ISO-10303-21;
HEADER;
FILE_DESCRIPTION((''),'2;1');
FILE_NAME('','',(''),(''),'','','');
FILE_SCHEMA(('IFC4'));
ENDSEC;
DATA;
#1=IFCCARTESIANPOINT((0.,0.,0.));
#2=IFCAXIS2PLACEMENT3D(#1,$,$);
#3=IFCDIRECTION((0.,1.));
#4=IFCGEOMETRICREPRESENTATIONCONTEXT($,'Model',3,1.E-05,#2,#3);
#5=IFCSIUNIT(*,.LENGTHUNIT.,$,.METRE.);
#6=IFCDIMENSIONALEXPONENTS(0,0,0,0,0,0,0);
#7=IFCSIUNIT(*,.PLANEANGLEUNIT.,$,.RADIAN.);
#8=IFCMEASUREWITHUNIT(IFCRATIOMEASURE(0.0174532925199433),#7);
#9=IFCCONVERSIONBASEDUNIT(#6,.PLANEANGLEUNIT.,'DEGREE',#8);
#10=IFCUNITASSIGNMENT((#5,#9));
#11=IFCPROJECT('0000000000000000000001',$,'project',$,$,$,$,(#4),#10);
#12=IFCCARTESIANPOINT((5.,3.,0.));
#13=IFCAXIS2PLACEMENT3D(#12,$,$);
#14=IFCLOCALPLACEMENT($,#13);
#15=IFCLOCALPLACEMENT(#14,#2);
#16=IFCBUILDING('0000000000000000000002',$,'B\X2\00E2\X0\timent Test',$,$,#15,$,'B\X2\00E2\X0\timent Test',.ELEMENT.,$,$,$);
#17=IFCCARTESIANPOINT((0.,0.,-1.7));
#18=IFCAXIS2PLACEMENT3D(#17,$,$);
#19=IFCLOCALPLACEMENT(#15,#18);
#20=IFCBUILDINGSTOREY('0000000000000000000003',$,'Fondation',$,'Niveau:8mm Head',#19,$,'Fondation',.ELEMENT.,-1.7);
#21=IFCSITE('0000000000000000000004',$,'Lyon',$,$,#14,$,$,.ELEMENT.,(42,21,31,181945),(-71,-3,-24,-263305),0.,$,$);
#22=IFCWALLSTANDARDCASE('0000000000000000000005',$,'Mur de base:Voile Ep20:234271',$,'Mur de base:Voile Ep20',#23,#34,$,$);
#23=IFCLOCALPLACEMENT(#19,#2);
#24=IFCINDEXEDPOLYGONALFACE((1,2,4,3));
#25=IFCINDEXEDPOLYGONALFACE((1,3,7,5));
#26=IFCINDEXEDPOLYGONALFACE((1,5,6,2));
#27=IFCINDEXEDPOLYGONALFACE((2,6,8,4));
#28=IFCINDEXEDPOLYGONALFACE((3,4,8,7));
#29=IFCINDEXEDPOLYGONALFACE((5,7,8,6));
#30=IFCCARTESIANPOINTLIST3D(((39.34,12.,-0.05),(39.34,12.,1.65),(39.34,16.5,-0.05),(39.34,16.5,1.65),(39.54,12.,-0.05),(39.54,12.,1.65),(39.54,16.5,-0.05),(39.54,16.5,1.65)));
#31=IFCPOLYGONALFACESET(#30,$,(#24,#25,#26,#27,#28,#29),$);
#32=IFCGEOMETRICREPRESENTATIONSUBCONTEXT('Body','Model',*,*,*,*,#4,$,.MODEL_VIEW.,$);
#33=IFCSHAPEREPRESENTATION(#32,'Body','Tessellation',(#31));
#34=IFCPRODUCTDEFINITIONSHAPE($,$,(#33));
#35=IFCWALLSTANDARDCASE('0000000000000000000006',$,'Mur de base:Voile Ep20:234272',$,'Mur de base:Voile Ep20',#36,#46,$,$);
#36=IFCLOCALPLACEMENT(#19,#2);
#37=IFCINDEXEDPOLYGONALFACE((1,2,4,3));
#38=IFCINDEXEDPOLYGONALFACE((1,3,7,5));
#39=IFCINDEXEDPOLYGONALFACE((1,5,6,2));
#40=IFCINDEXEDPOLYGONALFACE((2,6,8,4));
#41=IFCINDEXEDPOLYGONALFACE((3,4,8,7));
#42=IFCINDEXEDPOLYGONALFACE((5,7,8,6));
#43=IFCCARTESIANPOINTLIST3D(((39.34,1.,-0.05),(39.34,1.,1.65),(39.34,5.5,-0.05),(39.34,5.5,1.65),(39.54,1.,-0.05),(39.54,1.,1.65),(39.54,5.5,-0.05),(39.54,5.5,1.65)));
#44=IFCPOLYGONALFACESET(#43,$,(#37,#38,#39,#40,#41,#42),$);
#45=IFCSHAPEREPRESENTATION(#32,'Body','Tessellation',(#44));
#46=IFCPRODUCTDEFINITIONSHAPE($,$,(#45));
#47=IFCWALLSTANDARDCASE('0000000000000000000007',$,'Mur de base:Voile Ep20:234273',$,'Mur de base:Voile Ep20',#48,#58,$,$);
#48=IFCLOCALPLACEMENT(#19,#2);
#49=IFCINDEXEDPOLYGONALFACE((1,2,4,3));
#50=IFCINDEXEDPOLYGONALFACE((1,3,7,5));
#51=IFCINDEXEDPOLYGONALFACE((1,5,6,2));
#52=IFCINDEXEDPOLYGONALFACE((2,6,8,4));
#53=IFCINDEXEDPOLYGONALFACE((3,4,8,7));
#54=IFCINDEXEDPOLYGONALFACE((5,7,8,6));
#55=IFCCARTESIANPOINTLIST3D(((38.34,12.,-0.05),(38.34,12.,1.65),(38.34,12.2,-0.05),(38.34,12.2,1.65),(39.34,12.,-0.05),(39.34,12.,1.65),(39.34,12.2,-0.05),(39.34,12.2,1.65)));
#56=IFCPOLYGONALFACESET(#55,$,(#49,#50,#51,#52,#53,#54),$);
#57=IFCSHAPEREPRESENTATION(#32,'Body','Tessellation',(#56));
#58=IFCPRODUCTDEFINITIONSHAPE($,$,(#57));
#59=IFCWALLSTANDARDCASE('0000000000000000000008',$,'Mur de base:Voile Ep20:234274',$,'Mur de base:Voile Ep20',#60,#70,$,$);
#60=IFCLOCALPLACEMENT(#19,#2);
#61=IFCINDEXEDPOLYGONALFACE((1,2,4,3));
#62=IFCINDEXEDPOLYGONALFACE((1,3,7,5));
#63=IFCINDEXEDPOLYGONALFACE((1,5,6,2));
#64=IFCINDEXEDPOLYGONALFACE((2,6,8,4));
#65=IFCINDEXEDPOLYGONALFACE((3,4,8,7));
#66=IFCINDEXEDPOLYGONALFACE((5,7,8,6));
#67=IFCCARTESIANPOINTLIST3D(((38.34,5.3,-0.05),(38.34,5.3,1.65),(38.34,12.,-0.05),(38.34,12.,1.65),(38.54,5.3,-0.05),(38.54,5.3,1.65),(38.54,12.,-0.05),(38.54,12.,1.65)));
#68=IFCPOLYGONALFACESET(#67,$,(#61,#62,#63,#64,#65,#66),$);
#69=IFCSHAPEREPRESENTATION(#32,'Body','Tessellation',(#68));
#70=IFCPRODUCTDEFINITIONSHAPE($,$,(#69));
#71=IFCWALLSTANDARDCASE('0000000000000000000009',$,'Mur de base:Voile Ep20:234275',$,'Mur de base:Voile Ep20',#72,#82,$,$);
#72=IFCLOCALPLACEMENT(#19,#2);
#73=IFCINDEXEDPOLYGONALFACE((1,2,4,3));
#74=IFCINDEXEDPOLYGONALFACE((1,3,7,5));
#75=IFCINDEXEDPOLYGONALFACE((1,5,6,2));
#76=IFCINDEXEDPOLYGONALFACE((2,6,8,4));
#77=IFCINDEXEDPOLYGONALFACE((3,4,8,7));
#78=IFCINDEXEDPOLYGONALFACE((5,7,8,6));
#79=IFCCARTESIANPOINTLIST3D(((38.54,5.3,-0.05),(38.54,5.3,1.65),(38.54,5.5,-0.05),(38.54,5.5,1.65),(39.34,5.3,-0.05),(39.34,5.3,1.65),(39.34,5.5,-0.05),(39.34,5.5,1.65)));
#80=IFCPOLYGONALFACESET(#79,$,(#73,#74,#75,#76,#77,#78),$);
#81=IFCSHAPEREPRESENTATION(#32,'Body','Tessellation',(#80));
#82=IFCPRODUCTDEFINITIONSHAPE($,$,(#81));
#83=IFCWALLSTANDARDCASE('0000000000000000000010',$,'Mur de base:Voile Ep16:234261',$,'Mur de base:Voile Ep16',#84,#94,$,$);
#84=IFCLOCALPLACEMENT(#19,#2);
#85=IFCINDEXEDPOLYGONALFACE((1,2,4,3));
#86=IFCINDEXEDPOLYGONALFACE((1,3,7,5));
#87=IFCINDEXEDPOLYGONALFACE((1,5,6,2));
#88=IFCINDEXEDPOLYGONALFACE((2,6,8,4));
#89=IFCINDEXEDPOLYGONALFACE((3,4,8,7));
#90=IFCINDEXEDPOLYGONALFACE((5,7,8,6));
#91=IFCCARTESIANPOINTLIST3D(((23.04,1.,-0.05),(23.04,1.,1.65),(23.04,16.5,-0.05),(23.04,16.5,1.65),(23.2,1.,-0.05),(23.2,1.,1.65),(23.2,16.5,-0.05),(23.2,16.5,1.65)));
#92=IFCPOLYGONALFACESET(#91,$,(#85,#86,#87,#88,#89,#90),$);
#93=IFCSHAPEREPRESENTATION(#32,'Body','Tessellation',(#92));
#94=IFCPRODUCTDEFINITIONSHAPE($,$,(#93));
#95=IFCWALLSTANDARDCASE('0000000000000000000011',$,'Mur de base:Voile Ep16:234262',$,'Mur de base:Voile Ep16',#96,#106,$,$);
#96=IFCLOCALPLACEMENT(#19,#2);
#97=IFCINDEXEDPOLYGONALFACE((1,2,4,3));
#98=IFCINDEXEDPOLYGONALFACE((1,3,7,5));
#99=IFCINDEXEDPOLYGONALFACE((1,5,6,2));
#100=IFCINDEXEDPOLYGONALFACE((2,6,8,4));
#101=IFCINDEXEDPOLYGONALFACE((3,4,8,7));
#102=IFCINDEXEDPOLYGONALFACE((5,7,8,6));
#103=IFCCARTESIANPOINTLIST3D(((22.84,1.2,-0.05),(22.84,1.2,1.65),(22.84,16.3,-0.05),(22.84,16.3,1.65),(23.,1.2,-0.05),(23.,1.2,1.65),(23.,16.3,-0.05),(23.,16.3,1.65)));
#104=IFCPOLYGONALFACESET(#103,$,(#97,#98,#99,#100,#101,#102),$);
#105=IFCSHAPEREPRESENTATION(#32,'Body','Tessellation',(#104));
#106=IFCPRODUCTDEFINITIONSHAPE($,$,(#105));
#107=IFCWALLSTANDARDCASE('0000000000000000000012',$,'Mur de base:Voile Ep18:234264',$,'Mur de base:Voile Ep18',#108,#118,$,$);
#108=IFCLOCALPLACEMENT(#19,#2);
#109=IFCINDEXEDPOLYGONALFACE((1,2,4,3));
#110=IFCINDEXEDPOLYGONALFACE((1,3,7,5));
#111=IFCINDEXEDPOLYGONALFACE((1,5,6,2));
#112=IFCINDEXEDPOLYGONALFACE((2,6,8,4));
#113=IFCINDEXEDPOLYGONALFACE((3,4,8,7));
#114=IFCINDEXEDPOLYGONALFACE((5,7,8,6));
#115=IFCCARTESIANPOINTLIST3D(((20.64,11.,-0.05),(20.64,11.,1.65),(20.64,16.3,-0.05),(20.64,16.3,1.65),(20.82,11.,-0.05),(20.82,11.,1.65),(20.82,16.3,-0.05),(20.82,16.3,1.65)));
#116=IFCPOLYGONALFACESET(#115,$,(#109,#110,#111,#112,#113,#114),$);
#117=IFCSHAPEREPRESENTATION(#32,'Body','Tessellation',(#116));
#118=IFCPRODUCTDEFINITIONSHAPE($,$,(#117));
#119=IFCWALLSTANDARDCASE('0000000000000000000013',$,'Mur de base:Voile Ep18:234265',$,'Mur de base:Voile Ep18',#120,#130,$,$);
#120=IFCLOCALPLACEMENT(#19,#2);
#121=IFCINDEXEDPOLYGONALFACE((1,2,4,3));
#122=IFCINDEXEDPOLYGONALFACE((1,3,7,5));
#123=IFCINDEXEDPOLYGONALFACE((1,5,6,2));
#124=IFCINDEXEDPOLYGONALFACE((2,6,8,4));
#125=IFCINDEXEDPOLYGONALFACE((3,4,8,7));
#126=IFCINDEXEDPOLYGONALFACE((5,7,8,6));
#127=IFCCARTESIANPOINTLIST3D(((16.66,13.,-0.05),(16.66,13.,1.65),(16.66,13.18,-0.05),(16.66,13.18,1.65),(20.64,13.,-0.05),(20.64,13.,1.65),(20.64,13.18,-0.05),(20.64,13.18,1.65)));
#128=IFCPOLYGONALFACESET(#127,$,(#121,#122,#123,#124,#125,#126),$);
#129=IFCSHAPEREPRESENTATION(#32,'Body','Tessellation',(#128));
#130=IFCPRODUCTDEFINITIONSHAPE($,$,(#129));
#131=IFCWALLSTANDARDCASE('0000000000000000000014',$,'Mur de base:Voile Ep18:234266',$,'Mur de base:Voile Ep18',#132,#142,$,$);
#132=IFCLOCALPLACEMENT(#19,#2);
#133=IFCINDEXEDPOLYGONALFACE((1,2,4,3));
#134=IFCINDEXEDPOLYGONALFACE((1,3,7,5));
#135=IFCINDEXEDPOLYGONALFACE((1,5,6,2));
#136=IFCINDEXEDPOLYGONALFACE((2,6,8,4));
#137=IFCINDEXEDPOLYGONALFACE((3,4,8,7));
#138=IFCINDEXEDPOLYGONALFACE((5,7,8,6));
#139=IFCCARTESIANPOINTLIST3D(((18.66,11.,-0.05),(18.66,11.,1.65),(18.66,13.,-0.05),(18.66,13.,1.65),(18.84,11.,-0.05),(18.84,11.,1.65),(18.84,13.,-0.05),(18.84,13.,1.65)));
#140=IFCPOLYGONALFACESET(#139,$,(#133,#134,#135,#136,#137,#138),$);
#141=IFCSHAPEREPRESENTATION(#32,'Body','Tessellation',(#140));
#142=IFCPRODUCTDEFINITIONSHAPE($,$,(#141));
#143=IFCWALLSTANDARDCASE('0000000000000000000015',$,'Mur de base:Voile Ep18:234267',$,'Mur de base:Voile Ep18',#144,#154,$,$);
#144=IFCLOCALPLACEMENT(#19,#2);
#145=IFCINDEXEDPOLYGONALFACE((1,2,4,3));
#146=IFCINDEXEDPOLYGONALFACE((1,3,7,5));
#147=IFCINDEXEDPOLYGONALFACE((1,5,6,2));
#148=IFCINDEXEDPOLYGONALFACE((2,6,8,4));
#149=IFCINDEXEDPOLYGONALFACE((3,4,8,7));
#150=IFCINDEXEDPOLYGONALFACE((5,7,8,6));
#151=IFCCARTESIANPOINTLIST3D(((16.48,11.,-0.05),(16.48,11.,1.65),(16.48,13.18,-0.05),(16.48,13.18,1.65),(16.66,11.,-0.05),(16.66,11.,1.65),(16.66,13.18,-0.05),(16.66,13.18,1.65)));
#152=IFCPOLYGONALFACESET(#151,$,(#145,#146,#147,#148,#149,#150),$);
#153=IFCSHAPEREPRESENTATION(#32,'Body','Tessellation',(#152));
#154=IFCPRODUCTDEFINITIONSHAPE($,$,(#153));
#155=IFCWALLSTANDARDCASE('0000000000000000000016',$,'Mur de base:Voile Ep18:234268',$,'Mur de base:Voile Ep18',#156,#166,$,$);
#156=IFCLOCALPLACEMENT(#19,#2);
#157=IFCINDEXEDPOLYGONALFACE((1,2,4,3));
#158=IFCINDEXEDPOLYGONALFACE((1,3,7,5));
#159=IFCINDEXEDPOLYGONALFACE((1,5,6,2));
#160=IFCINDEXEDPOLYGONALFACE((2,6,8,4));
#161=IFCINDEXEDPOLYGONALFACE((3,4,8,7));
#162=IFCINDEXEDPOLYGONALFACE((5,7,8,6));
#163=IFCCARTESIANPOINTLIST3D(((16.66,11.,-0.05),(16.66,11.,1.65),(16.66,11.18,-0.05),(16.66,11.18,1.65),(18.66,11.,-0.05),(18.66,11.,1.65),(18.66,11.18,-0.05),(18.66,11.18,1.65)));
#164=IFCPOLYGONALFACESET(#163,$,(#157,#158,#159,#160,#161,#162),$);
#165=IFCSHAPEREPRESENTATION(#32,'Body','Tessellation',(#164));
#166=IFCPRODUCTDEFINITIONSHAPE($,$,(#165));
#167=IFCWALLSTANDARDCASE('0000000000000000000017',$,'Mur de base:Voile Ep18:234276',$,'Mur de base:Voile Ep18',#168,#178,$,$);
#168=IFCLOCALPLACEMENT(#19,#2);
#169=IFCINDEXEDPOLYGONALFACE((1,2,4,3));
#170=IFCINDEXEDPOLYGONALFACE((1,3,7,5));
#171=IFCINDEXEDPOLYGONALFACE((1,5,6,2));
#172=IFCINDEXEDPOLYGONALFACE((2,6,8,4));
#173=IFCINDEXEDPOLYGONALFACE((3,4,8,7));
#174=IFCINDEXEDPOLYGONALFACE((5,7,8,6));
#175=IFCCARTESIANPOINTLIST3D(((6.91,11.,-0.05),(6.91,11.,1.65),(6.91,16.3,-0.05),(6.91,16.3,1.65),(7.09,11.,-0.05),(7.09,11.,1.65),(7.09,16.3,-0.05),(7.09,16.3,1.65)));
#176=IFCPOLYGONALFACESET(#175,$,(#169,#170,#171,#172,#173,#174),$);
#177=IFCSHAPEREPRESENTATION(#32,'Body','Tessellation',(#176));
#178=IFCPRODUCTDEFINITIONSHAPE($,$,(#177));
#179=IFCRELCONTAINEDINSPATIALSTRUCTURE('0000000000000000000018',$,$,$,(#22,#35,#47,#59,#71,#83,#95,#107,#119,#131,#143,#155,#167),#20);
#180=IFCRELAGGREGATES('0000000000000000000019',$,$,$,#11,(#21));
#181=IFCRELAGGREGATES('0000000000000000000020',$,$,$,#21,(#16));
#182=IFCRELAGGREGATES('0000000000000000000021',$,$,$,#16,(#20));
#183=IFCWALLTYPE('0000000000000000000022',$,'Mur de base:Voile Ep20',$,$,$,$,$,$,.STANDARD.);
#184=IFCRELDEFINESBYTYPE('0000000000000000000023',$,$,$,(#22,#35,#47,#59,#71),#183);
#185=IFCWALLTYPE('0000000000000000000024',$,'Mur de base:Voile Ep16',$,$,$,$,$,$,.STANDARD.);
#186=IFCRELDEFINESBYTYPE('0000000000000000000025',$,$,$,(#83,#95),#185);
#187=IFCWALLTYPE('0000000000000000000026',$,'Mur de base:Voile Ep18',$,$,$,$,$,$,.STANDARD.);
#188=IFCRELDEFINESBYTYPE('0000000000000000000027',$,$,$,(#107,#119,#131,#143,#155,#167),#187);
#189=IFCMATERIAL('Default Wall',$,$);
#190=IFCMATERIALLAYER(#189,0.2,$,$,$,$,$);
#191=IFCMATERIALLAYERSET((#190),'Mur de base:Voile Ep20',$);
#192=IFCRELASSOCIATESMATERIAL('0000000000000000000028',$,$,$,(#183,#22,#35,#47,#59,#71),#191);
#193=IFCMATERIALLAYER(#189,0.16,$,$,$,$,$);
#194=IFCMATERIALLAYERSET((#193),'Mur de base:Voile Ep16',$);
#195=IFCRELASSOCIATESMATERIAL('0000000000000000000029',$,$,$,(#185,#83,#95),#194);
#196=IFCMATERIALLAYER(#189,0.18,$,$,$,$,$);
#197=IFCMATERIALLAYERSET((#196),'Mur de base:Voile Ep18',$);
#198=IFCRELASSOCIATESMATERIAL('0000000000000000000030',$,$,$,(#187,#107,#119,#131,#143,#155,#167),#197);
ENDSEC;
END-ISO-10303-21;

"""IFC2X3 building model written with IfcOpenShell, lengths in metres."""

from ifc_helpers import new_model, entity, si_unit, converted_unit, direction, frame, frame_2d, origin, place, context, subcontext, project, spatial, rectangle, extrude, material, layer, layer_set, layer_usage, type_object, element, save


model = new_model("IFC2X3")

# Units and contexts
model_context = context("Model", 3, precision=1e-05, world=origin(), true_north=direction((0.0, 1.0)))
body_context = subcontext(model_context, "Body", "Model", "MODEL_VIEW")
ifc_project = project(units=[si_unit("LENGTHUNIT", "METRE"), converted_unit("PLANEANGLEUNIT", "DEGREE", entity("IfcRatioMeasure", 0.0174532925199433), si_unit("PLANEANGLEUNIT", "RADIAN"), dimensions=[0, 0, 0, 0, 0, 0, 0])], contexts=[model_context])

# Site, building, storey
site_placement = place(None, frame((5.0, 3.0, 0.0)))
site = spatial("IfcSite", under=ifc_project, at=site_placement, Name="Lyon", CompositionType="ELEMENT", RefLatitude=(42, 21, 31, 181945), RefLongitude=(-71, -3, -24, -263305), RefElevation=0.0)
building_placement = place(site_placement, origin())
building = spatial("IfcBuilding", under=site, at=building_placement, Name="Bâtiment Test", LongName="Bâtiment Test", CompositionType="ELEMENT")
storey_placement = place(building_placement, frame((0.0, 0.0, -1.7)))
storey = spatial("IfcBuildingStorey", under=building, at=storey_placement, Name="Fondation", ObjectType="Niveau:8mm Head", LongName="Fondation", CompositionType="ELEMENT", Elevation=-1.7)

# Walls
ifc_material_1 = material(Name="Default Wall")
ifc_layer_1 = layer(ifc_material_1, 0.2)
ifc_layer_set_1 = layer_set([ifc_layer_1], Name="Mur de base:Voile Ep20")
wall_type_1 = type_object("IfcWallType", Name="Mur de base:Voile Ep20", PredefinedType="STANDARD", material=ifc_layer_set_1)
ifc_layer_usage_1 = layer_usage(ifc_layer_set_1, "AXIS2", "NEGATIVE", 0.1)
wall_1_placement = place(storey_placement, frame((39.44, 16.5, -0.05), z_axis=(0.0, 0.0, 1.0), x_axis=(0.0, -1.0, 0.0)))
element("IfcWallStandardCase", 1, at=wall_1_placement, inside=storey, type_object=wall_type_1, material=ifc_layer_usage_1, Name="Mur de base:Voile Ep20:234271", ObjectType="Mur de base:Voile Ep20", context=body_context, shape_type="SweptSolid", body=[
    extrude(rectangle(XDim=4.5, YDim=0.2, at=frame_2d((2.25, 0.0), x_axis=(-1.0, 0.0))), origin(), (0.0, 0.0, 1.0), 1.7),
])
ifc_layer_usage_2 = layer_usage(ifc_layer_set_1, "AXIS2", "NEGATIVE", 0.1)
wall_2_placement = place(storey_placement, frame((39.44, 5.5, -0.05), z_axis=(0.0, 0.0, 1.0), x_axis=(0.0, -1.0, 0.0)))
element("IfcWallStandardCase", 2, at=wall_2_placement, inside=storey, type_object=wall_type_1, material=ifc_layer_usage_2, Name="Mur de base:Voile Ep20:234272", ObjectType="Mur de base:Voile Ep20", context=body_context, shape_type="SweptSolid", body=[
    extrude(rectangle(XDim=4.5, YDim=0.2, at=frame_2d((2.25, 0.0), x_axis=(-1.0, 0.0))), origin(), (0.0, 0.0, 1.0), 1.7),
])
ifc_layer_usage_3 = layer_usage(ifc_layer_set_1, "AXIS2", "NEGATIVE", 0.1)
wall_3_placement = place(storey_placement, frame((39.34, 12.1, -0.05), z_axis=(0.0, 0.0, 1.0), x_axis=(-1.0, 0.0, 0.0)))
element("IfcWallStandardCase", 3, at=wall_3_placement, inside=storey, type_object=wall_type_1, material=ifc_layer_usage_3, Name="Mur de base:Voile Ep20:234273", ObjectType="Mur de base:Voile Ep20", context=body_context, shape_type="SweptSolid", body=[
    extrude(rectangle(XDim=1.0, YDim=0.2, at=frame_2d((0.5, 0.0), x_axis=(-1.0, 0.0))), origin(), (0.0, 0.0, 1.0), 1.7),
])
ifc_layer_usage_4 = layer_usage(ifc_layer_set_1, "AXIS2", "NEGATIVE", 0.1)
wall_4_placement = place(storey_placement, frame((38.44, 12.0, -0.05), z_axis=(0.0, 0.0, 1.0), x_axis=(0.0, -1.0, 0.0)))
element("IfcWallStandardCase", 4, at=wall_4_placement, inside=storey, type_object=wall_type_1, material=ifc_layer_usage_4, Name="Mur de base:Voile Ep20:234274", ObjectType="Mur de base:Voile Ep20", context=body_context, shape_type="SweptSolid", body=[
    extrude(rectangle(XDim=6.7, YDim=0.2, at=frame_2d((3.35, 0.0), x_axis=(-1.0, 0.0))), origin(), (0.0, 0.0, 1.0), 1.7),
])
ifc_layer_usage_5 = layer_usage(ifc_layer_set_1, "AXIS2", "NEGATIVE", 0.1)
wall_5_placement = place(storey_placement, frame((38.54, 5.4, -0.05)))
element("IfcWallStandardCase", 5, at=wall_5_placement, inside=storey, type_object=wall_type_1, material=ifc_layer_usage_5, Name="Mur de base:Voile Ep20:234275", ObjectType="Mur de base:Voile Ep20", context=body_context, shape_type="SweptSolid", body=[
    extrude(rectangle(XDim=0.8, YDim=0.2, at=frame_2d((0.4, 0.0), x_axis=(-1.0, 0.0))), origin(), (0.0, 0.0, 1.0), 1.7),
])
ifc_layer_2 = layer(ifc_material_1, 0.16)
ifc_layer_set_2 = layer_set([ifc_layer_2], Name="Mur de base:Voile Ep16")
ifc_layer_usage_6 = layer_usage(ifc_layer_set_2, "AXIS2", "NEGATIVE", 0.08)
wall_type_2 = type_object("IfcWallType", Name="Mur de base:Voile Ep16", PredefinedType="STANDARD", material=ifc_layer_set_2)
wall_6_placement = place(storey_placement, frame((23.12, 1.0, -0.05), z_axis=(0.0, 0.0, 1.0), x_axis=(0.0, 1.0, 0.0)))
element("IfcWallStandardCase", 6, at=wall_6_placement, inside=storey, type_object=wall_type_2, material=ifc_layer_usage_6, Name="Mur de base:Voile Ep16:234261", ObjectType="Mur de base:Voile Ep16", context=body_context, shape_type="SweptSolid", body=[
    extrude(rectangle(XDim=15.5, YDim=0.16, at=frame_2d((7.75, 0.0), x_axis=(-1.0, 0.0))), origin(), (0.0, 0.0, 1.0), 1.7),
])
ifc_layer_usage_7 = layer_usage(ifc_layer_set_2, "AXIS2", "NEGATIVE", 0.08)
wall_7_placement = place(storey_placement, frame((22.92, 16.3, -0.05), z_axis=(0.0, 0.0, 1.0), x_axis=(0.0, -1.0, 0.0)))
element("IfcWallStandardCase", 7, at=wall_7_placement, inside=storey, type_object=wall_type_2, material=ifc_layer_usage_7, Name="Mur de base:Voile Ep16:234262", ObjectType="Mur de base:Voile Ep16", context=body_context, shape_type="SweptSolid", body=[
    extrude(rectangle(XDim=15.1, YDim=0.16, at=frame_2d((7.55, 0.0), x_axis=(-1.0, 0.0))), origin(), (0.0, 0.0, 1.0), 1.7),
])
ifc_layer_3 = layer(ifc_material_1, 0.18)
ifc_layer_set_3 = layer_set([ifc_layer_3], Name="Mur de base:Voile Ep18")
ifc_layer_usage_8 = layer_usage(ifc_layer_set_3, "AXIS2", "NEGATIVE", 0.09)
wall_type_3 = type_object("IfcWallType", Name="Mur de base:Voile Ep18", PredefinedType="STANDARD", material=ifc_layer_set_3)
wall_8_placement = place(storey_placement, frame((20.73, 16.3, -0.05), z_axis=(0.0, 0.0, 1.0), x_axis=(0.0, -1.0, 0.0)))
element("IfcWallStandardCase", 8, at=wall_8_placement, inside=storey, type_object=wall_type_3, material=ifc_layer_usage_8, Name="Mur de base:Voile Ep18:234264", ObjectType="Mur de base:Voile Ep18", context=body_context, shape_type="SweptSolid", body=[
    extrude(rectangle(XDim=5.3, YDim=0.18, at=frame_2d((2.65, 0.0), x_axis=(-1.0, 0.0))), origin(), (0.0, 0.0, 1.0), 1.7),
])
ifc_layer_usage_9 = layer_usage(ifc_layer_set_3, "AXIS2", "NEGATIVE", 0.09)
wall_9_placement = place(storey_placement, frame((20.64, 13.09, -0.05), z_axis=(0.0, 0.0, 1.0), x_axis=(-1.0, 0.0, 0.0)))
element("IfcWallStandardCase", 9, at=wall_9_placement, inside=storey, type_object=wall_type_3, material=ifc_layer_usage_9, Name="Mur de base:Voile Ep18:234265", ObjectType="Mur de base:Voile Ep18", context=body_context, shape_type="SweptSolid", body=[
    extrude(rectangle(XDim=3.98, YDim=0.18, at=frame_2d((1.99, 0.0), x_axis=(-1.0, 0.0))), origin(), (0.0, 0.0, 1.0), 1.7),
])
ifc_layer_usage_10 = layer_usage(ifc_layer_set_3, "AXIS2", "NEGATIVE", 0.09)
wall_10_placement = place(storey_placement, frame((18.75, 13.0, -0.05), z_axis=(0.0, 0.0, 1.0), x_axis=(0.0, -1.0, 0.0)))
element("IfcWallStandardCase", 10, at=wall_10_placement, inside=storey, type_object=wall_type_3, material=ifc_layer_usage_10, Name="Mur de base:Voile Ep18:234266", ObjectType="Mur de base:Voile Ep18", context=body_context, shape_type="SweptSolid", body=[
    extrude(rectangle(XDim=2.0, YDim=0.18, at=frame_2d((1.0, 0.0), x_axis=(-1.0, 0.0))), origin(), (0.0, 0.0, 1.0), 1.7),
])
ifc_layer_usage_11 = layer_usage(ifc_layer_set_3, "AXIS2", "NEGATIVE", 0.09)
wall_11_placement = place(storey_placement, frame((16.57, 13.18, -0.05), z_axis=(0.0, 0.0, 1.0), x_axis=(0.0, -1.0, 0.0)))
element("IfcWallStandardCase", 11, at=wall_11_placement, inside=storey, type_object=wall_type_3, material=ifc_layer_usage_11, Name="Mur de base:Voile Ep18:234267", ObjectType="Mur de base:Voile Ep18", context=body_context, shape_type="SweptSolid", body=[
    extrude(rectangle(XDim=2.18, YDim=0.18, at=frame_2d((1.09, 0.0), x_axis=(-1.0, 0.0))), origin(), (0.0, 0.0, 1.0), 1.7),
])
ifc_layer_usage_12 = layer_usage(ifc_layer_set_3, "AXIS2", "POSITIVE", -0.09)
wall_12_placement = place(storey_placement, frame((16.66, 11.09, -0.05)))
element("IfcWallStandardCase", 12, at=wall_12_placement, inside=storey, type_object=wall_type_3, material=ifc_layer_usage_12, Name="Mur de base:Voile Ep18:234268", ObjectType="Mur de base:Voile Ep18", context=body_context, shape_type="SweptSolid", body=[
    extrude(rectangle(XDim=2.0, YDim=0.18, at=frame_2d((1.0, 0.0), x_axis=(-1.0, 0.0))), origin(), (0.0, 0.0, 1.0), 1.7),
])
ifc_layer_usage_13 = layer_usage(ifc_layer_set_3, "AXIS2", "NEGATIVE", 0.09)
wall_13_placement = place(storey_placement, frame((7.0, 16.3, -0.05), z_axis=(0.0, 0.0, 1.0), x_axis=(0.0, -1.0, 0.0)))
element("IfcWallStandardCase", 13, at=wall_13_placement, inside=storey, type_object=wall_type_3, material=ifc_layer_usage_13, Name="Mur de base:Voile Ep18:234276", ObjectType="Mur de base:Voile Ep18", context=body_context, shape_type="SweptSolid", body=[
    extrude(rectangle(XDim=5.3, YDim=0.18, at=frame_2d((2.65, 0.0), x_axis=(-1.0, 0.0))), origin(), (0.0, 0.0, 1.0), 1.7),
])

save(model, "model.ifc")
